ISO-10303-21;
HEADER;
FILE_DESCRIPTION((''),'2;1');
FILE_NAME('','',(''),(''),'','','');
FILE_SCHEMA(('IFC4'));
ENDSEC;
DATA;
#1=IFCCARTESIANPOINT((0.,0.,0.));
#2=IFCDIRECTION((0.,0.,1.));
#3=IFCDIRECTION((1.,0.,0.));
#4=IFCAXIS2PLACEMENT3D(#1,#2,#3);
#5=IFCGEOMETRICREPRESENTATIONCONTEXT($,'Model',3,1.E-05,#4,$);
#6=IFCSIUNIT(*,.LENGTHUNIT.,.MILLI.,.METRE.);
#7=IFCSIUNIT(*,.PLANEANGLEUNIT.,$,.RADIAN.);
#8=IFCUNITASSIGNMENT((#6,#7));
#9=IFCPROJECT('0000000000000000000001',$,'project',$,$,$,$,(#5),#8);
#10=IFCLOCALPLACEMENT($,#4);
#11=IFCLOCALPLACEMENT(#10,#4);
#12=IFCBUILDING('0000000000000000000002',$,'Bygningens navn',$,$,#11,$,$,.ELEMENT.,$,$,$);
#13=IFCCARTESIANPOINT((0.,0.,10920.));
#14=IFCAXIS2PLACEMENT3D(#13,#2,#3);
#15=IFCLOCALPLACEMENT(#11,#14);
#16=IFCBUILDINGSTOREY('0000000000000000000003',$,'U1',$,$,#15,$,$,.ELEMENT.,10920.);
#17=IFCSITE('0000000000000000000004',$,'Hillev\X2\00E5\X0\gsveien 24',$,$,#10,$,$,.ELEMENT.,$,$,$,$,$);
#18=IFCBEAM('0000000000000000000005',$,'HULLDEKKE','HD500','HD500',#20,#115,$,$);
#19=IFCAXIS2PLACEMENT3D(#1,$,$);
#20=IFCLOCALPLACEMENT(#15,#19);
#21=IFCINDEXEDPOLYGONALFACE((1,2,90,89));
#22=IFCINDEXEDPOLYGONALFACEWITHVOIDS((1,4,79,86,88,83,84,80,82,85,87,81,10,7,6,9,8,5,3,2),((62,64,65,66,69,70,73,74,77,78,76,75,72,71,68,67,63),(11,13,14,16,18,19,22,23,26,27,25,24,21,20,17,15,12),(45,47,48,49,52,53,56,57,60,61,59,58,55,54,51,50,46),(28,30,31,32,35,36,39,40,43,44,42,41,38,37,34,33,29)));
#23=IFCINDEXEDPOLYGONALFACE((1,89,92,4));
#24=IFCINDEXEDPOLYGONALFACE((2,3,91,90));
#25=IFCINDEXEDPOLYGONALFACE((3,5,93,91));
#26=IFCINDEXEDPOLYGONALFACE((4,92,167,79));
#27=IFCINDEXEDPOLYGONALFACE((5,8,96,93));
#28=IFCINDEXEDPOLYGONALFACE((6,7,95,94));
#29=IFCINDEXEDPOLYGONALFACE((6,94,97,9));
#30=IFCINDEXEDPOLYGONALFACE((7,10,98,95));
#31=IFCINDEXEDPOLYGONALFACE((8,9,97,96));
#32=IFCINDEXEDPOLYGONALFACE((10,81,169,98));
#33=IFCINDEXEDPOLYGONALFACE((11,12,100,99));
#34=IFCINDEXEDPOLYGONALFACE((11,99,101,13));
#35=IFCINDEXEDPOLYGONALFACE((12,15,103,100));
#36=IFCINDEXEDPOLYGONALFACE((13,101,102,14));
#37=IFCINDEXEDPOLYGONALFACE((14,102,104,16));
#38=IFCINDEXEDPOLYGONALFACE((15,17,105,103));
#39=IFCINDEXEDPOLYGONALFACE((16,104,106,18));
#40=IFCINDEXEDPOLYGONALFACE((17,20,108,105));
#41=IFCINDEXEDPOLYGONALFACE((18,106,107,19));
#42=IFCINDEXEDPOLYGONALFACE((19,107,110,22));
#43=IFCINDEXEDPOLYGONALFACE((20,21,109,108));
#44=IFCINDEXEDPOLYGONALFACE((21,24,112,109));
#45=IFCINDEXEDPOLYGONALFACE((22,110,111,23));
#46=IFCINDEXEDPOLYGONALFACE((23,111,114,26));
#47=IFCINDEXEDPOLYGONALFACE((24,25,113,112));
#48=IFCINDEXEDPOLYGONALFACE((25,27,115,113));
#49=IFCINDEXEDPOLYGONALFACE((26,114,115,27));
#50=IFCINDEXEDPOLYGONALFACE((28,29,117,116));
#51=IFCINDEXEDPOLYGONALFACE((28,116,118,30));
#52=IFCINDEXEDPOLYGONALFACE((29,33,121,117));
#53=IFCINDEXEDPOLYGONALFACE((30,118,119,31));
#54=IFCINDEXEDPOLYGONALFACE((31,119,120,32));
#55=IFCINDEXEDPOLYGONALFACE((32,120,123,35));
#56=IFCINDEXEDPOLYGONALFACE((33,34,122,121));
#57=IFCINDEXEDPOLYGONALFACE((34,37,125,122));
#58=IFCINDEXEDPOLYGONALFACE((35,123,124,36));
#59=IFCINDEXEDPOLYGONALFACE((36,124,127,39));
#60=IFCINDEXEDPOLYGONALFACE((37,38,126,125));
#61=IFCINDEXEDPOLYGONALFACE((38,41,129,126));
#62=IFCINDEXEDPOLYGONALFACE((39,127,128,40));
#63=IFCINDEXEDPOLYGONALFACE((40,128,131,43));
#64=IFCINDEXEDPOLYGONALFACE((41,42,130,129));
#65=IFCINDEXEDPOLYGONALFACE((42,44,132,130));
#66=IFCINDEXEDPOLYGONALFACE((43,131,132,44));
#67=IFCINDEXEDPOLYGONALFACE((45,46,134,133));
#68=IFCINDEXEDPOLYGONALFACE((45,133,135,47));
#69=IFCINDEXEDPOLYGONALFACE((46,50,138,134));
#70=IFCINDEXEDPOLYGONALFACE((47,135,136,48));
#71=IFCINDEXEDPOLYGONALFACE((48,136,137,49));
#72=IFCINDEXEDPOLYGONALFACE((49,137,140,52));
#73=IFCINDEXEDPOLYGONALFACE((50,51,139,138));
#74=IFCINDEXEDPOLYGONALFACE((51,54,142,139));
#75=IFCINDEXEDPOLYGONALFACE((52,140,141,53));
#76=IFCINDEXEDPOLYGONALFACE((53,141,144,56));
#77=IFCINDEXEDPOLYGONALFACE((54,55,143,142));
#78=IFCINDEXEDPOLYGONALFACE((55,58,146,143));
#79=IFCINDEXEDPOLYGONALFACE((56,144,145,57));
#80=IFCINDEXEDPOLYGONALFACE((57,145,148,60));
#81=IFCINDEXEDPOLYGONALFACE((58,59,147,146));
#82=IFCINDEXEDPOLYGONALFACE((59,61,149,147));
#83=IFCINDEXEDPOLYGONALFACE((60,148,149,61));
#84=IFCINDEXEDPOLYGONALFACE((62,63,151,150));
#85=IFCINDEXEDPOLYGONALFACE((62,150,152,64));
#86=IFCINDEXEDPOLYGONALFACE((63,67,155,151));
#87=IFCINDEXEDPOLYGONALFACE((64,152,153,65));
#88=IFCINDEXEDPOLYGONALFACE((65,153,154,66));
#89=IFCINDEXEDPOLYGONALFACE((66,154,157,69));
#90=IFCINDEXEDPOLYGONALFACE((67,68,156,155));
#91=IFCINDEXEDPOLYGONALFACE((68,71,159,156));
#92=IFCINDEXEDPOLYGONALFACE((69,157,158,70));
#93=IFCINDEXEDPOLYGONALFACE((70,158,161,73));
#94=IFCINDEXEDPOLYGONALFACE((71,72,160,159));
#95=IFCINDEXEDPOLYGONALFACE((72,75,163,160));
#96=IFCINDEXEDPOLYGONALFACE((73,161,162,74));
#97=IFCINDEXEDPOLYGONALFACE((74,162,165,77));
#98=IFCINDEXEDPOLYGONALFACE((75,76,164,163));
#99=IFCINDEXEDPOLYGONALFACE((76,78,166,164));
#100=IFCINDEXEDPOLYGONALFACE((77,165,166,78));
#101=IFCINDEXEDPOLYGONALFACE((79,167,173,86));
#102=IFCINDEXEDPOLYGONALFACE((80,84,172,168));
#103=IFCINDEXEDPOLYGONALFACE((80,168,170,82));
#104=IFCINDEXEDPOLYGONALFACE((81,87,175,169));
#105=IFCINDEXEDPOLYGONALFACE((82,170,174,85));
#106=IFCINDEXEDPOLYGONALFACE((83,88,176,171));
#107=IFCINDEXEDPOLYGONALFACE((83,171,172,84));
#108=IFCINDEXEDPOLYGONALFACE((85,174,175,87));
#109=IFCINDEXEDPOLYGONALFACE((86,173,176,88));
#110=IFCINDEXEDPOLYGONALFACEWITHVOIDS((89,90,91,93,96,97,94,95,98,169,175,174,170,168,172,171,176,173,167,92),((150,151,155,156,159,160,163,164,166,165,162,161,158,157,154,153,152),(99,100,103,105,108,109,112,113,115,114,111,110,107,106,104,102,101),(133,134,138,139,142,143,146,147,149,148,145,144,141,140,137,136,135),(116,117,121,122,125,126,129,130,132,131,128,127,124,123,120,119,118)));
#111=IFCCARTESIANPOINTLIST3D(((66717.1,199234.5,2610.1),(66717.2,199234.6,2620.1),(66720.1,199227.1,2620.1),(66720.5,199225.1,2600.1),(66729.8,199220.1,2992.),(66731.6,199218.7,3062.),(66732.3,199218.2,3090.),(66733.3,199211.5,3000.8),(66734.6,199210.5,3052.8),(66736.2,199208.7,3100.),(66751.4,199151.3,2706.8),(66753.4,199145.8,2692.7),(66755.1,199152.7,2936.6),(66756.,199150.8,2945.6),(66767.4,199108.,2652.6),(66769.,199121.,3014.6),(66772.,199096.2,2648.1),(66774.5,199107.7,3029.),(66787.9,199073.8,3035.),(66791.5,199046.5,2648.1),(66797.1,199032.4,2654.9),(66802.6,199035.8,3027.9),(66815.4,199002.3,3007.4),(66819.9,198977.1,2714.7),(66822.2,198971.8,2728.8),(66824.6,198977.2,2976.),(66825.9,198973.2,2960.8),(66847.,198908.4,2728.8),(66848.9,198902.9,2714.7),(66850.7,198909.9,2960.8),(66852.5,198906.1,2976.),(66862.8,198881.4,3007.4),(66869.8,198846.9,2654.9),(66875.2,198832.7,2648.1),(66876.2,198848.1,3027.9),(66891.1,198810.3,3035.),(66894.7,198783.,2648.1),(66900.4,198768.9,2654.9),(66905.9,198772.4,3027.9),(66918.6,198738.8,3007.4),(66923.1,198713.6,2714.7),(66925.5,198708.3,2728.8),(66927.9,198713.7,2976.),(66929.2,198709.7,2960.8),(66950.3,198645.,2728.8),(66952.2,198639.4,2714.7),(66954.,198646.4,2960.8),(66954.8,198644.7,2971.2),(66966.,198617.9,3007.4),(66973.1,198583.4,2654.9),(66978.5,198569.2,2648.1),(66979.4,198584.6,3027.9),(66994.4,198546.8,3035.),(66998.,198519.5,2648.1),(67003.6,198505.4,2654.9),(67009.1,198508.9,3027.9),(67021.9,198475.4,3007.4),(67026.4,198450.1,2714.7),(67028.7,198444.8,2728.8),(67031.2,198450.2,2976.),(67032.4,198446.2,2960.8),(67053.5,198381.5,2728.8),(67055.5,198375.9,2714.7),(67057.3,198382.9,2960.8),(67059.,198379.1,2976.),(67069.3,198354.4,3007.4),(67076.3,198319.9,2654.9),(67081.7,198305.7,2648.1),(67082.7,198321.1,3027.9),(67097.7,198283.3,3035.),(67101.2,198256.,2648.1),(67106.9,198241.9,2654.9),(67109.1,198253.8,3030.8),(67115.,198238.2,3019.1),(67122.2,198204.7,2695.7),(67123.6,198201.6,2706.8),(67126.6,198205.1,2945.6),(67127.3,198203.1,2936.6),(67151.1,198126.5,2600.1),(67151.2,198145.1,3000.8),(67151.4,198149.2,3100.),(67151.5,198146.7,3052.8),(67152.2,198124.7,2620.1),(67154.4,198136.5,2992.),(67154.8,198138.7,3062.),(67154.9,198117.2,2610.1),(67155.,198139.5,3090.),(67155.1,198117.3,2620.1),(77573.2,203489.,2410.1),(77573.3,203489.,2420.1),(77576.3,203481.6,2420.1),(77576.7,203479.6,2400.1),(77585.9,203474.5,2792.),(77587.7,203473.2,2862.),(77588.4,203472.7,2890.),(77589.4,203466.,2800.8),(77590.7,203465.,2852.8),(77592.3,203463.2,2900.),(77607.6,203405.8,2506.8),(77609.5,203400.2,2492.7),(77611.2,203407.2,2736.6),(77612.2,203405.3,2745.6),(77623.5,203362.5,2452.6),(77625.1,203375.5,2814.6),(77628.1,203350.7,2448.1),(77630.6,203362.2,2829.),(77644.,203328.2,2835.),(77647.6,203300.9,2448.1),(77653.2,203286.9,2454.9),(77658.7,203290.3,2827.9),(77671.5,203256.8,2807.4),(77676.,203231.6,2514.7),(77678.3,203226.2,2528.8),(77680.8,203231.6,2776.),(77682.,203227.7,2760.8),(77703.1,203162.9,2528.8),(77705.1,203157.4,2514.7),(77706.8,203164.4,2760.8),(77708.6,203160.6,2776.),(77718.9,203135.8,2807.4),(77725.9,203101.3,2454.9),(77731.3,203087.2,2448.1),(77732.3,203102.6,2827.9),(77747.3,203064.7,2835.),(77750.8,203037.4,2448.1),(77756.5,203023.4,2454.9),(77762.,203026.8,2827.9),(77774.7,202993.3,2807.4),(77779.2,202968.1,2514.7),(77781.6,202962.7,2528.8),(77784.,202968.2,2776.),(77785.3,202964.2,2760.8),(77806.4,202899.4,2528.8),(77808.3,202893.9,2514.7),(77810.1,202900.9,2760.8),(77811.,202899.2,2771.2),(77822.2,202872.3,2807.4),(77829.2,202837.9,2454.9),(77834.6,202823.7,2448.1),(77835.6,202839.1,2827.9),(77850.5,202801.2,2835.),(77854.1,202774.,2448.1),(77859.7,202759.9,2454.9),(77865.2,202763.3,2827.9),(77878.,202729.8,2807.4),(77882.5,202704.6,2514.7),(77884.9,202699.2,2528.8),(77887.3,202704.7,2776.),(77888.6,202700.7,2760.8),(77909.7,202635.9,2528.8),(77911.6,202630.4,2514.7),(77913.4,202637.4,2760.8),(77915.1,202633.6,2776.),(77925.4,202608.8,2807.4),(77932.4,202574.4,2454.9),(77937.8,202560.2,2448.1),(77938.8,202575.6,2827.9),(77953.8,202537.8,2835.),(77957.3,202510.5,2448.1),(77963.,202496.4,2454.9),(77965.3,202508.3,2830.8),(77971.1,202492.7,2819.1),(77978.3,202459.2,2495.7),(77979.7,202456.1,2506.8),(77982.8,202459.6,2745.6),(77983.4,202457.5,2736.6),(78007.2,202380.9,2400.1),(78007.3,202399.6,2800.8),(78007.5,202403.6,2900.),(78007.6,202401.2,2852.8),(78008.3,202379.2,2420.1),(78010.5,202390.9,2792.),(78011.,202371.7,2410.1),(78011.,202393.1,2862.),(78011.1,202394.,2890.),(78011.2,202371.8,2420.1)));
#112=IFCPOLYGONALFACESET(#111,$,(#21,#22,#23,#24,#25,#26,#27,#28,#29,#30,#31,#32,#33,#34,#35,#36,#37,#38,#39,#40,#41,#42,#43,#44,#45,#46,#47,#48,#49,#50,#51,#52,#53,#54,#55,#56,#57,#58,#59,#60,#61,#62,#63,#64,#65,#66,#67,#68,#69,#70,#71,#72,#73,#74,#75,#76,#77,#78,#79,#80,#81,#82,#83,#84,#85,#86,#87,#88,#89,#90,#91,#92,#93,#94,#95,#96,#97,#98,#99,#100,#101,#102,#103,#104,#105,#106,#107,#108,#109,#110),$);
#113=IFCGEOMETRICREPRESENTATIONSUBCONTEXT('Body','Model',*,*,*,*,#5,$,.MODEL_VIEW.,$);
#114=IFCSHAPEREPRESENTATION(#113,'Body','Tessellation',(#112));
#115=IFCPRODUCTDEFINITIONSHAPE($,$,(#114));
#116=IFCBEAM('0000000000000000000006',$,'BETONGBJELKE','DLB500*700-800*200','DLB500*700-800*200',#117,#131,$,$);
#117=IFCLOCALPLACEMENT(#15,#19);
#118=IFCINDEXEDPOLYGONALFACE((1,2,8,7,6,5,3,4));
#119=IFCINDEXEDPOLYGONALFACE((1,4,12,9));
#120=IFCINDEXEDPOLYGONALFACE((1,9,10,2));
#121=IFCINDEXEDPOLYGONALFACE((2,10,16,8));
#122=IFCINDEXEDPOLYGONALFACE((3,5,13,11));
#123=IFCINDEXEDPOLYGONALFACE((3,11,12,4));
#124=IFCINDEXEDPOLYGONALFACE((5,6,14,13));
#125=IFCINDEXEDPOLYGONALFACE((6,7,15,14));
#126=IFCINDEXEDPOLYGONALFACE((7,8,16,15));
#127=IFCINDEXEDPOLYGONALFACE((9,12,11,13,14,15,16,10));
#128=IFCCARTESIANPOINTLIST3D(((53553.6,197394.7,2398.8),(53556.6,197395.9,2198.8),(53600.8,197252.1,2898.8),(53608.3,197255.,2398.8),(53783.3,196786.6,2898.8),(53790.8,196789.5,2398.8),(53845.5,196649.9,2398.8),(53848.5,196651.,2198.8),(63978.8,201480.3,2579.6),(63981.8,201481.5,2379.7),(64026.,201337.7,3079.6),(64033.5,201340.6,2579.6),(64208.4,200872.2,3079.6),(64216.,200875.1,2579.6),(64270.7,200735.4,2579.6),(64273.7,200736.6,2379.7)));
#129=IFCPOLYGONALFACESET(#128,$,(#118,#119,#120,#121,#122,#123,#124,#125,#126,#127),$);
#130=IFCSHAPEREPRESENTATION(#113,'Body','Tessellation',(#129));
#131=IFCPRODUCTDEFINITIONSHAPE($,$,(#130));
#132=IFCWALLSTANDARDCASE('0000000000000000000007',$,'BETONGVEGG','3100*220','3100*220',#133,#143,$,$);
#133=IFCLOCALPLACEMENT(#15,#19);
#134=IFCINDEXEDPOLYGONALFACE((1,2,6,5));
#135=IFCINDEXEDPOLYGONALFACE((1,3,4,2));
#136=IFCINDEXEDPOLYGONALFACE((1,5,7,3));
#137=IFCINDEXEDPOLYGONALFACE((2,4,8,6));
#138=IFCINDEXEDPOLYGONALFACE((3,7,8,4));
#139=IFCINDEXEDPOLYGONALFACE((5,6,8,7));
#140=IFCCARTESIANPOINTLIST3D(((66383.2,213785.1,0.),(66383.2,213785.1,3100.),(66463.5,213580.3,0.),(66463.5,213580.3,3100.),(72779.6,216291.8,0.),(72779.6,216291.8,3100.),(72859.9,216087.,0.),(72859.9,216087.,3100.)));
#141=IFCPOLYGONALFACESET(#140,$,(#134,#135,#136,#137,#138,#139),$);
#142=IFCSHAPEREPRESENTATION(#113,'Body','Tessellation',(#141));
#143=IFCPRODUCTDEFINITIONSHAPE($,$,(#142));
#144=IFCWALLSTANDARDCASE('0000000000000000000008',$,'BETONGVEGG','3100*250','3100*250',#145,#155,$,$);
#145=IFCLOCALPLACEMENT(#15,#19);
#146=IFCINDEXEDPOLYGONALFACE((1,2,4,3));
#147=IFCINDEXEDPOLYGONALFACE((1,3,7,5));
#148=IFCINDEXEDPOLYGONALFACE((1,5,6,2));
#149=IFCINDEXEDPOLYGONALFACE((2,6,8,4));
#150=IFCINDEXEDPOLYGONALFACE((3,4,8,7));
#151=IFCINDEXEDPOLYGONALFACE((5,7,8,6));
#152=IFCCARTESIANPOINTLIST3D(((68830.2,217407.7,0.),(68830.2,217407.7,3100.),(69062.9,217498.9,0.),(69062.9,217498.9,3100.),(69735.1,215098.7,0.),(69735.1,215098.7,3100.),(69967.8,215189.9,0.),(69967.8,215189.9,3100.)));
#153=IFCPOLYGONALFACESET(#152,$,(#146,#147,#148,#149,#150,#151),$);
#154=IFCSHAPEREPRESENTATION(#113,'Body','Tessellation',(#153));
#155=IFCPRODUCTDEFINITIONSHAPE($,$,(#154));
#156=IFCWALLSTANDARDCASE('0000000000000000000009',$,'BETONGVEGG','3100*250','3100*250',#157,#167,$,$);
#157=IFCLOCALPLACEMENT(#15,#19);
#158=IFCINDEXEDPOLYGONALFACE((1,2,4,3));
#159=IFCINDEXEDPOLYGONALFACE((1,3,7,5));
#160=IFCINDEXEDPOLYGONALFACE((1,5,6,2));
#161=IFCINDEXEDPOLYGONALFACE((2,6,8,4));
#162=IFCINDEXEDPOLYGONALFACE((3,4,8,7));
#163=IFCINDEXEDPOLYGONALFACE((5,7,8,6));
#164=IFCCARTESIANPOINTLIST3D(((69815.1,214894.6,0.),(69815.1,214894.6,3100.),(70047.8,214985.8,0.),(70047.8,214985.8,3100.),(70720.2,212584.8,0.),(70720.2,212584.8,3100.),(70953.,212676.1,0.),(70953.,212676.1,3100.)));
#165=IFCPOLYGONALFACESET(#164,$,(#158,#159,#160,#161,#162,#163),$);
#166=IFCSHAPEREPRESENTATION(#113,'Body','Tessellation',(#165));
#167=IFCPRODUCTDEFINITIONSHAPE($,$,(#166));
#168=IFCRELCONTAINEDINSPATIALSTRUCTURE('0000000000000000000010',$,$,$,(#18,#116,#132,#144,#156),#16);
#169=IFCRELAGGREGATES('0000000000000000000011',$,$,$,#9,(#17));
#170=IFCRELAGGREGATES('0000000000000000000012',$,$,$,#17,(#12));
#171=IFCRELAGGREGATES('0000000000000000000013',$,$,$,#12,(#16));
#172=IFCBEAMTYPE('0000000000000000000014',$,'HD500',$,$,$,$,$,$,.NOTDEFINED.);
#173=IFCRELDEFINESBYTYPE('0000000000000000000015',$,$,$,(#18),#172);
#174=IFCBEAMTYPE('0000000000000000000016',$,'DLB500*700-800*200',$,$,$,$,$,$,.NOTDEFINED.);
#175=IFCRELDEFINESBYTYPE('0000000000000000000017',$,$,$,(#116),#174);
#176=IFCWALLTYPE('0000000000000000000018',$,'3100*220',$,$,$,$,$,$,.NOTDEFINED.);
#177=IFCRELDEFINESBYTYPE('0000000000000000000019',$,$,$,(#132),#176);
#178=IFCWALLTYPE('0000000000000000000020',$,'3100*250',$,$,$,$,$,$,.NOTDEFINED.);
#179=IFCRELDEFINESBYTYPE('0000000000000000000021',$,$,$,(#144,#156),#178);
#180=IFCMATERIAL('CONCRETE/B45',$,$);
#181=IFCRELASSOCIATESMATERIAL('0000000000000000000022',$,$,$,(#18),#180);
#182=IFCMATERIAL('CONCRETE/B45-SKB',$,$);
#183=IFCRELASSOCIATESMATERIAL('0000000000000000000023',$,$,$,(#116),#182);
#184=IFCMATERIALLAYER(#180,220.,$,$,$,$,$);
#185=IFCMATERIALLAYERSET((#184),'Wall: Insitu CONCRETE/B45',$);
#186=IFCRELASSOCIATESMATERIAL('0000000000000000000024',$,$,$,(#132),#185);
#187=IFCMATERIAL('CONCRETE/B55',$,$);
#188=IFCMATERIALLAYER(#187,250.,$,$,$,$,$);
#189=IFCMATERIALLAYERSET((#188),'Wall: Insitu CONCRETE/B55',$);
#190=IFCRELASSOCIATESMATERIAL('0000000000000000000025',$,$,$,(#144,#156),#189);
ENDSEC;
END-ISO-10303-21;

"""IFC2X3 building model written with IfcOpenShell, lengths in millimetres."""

from ifc_helpers import new_model, si_unit, frame, frame_2d, origin_with_axes, place, context, subcontext, project, spatial, polyline, rectangle, outline, extrude, material, layer, layer_set, layer_usage, type_object, element, save


model = new_model("IFC2X3")

# Units and contexts
model_context = context("Model", 3, precision=1e-05, world=origin_with_axes())
body_context = subcontext(model_context, "Body", "Model", "MODEL_VIEW")
ifc_project = project(units=[si_unit("LENGTHUNIT", "METRE", prefix="MILLI"), si_unit("PLANEANGLEUNIT", "RADIAN")], contexts=[model_context])

# Site, building, storey
site_placement = place(None, origin_with_axes())
site = spatial("IfcSite", under=ifc_project, at=site_placement, Name="Hillevågsveien 24", CompositionType="ELEMENT")
building_placement = place(site_placement, origin_with_axes())
building = spatial("IfcBuilding", under=site, at=building_placement, Name="Bygningens navn", CompositionType="ELEMENT")
storey_placement = place(building_placement, frame((0.0, 0.0, 10920.0), z_axis=(0.0, 0.0, 1.0), x_axis=(1.0, 0.0, 0.0)))
storey = spatial("IfcBuildingStorey", under=building, at=storey_placement, Name="U1", CompositionType="ELEMENT", Elevation=10920.0)

# Shared definitions
ifc_material_1 = material(Name="CONCRETE/B55")

# Beams
ifc_material_2 = material(Name="CONCRETE/B45")
beam_type_1 = type_object("IfcBeamType", Name="HD500", PredefinedType="NOTDEFINED")
beam_1_placement = place(storey_placement, frame((66939.8, 198677.4, 2850.0), z_axis=(0.015968, 0.006258, 0.999853), x_axis=(0.930919, 0.364823, -0.01715)))
element("IfcBeam", 1, at=beam_1_placement, inside=storey, type_object=beam_type_1, material=ifc_material_2, Name="HULLDEKKE", Description="HD500", ObjectType="HD500", context=body_context, shape_type="SweptSolid", body=[
    extrude(outline(polyline([(581.9, 142.0), (592.0, -230.0), (600.0, -230.0), (600.0, -240.0), (590.0, -250.0), (-590.0, -250.0), (-600.0, -240.0), (-600.0, -230.0), (-592.0, -230.0), (-581.9, 142.0), (-572.7, 150.7), (-571.3, 202.8), (-580.0, 212.0), (-579.3, 240.0), (-569.0, 250.0), (569.0, 250.0), (579.3, 240.0), (580.0, 212.0), (571.3, 202.8), (572.7, 150.7), (581.9, 142.0)]), holes=[polyline([(466.4, -195.1), (506.6, -154.3), (510.0, -143.2), (510.0, 86.5), (507.8, 95.6), (472.8, 169.1), (456.2, 180.7), (424.5, 185.0), (383.8, 177.9), (348.0, 157.4), (321.2, 126.0), (317.0, 110.8), (317.0, -121.2), (322.9, -135.4), (382.6, -195.1), (397.8, -202.0), (451.2, -202.0), (466.4, -195.1)]), polyline([(183.4, -195.1), (243.1, -135.4), (249.0, -121.2), (249.0, 110.8), (244.8, 126.0), (218.0, 157.4), (182.2, 177.9), (141.5, 185.0), (100.8, 177.9), (65.0, 157.4), (35.9, 121.2), (34.0, 110.8), (34.0, -121.2), (39.9, -135.4), (99.6, -195.1), (114.8, -202.0), (168.2, -202.0), (183.4, -195.1)]), polyline([(-99.6, -195.1), (-39.9, -135.4), (-34.0, -121.2), (-34.0, 110.8), (-38.2, 126.0), (-65.0, 157.4), (-100.8, 177.9), (-141.5, 185.0), (-182.2, 177.9), (-218.0, 157.4), (-244.8, 126.0), (-249.0, 110.8), (-249.0, -121.2), (-243.1, -135.4), (-183.4, -195.1), (-168.2, -202.0), (-114.8, -202.0), (-99.6, -195.1)]), polyline([(-382.6, -195.1), (-322.9, -135.4), (-317.0, -121.2), (-317.0, 110.8), (-321.2, 126.0), (-348.0, 157.4), (-383.8, 177.9), (-424.5, 185.0), (-461.0, 179.0), (-475.4, 164.6), (-507.9, 95.6), (-510.0, 86.5), (-510.0, -143.2), (-504.1, -157.4), (-463.9, -197.5), (-451.2, -202.0), (-397.8, -202.0), (-382.6, -195.1)])]), frame((11661.7, 0.0, 0.0), z_axis=(-1.0, 0.0, 0.0), x_axis=(0.0, -1.0, 0.0)), (0.0, 0.0, 1.0), 11661.7),
])
ifc_material_3 = material(Name="CONCRETE/B45-SKB")
beam_type_2 = type_object("IfcBeamType", Name="DLB500*700-800*200", PredefinedType="NOTDEFINED")
beam_2_placement = place(storey_placement, frame((64122.5, 201107.0, 2729.6), z_axis=(-0.015033, -0.005891, 0.99987), x_axis=(-0.930934, -0.364829, -0.016146)))
element("IfcBeam", 2, at=beam_2_placement, inside=storey, type_object=beam_type_2, material=ifc_material_3, Name="BETONGBJELKE", Description="DLB500*700-800*200", ObjectType="DLB500*700-800*200", context=body_context, shape_type="SweptSolid", body=[
    extrude(outline(polyline([(400.0, -150.0), (400.0, -350.0), (-400.0, -350.0), (-400.0, -150.0), (-250.0, -150.0), (-250.0, 350.0), (250.0, 350.0), (250.0, -150.0), (400.0, -150.0)])), frame((11198.6, 0.0, 0.0), z_axis=(-1.0, 0.0, 0.0), x_axis=(0.0, -1.0, 0.0)), (0.0, 0.0, 1.0), 11198.6),
])

# Walls
ifc_layer_1 = layer(ifc_material_2, 220.0)
ifc_layer_set_1 = layer_set([ifc_layer_1], Name="Wall: Insitu CONCRETE/B45")
ifc_layer_usage_1 = layer_usage(ifc_layer_set_1, "AXIS2", "POSITIVE", -110.0)
wall_type_1 = type_object("IfcWallType", Name="3100*220", PredefinedType="NOTDEFINED")
wall_1_placement = place(storey_placement, frame((66423.4, 213682.7, 0.0), z_axis=(0.0, 0.0, 1.0), x_axis=(0.931056, 0.364877, 0.0)))
element("IfcWallStandardCase", 3, at=wall_1_placement, inside=storey, type_object=wall_type_1, material=ifc_layer_usage_1, Name="BETONGVEGG", Description="3100*220", ObjectType="3100*220", context=body_context, shape_type="SweptSolid", body=[
    extrude(rectangle(XDim=6870.0, YDim=220.0, at=frame_2d((0.0, 3435.0), x_axis=(0.0, -1.0))), frame((0.0, 0.0, 0.0), z_axis=(0.0, 0.0, 1.0), x_axis=(0.0, -1.0, 0.0)), (0.0, 0.0, 1.0), 3100.0),
])
ifc_layer_2 = layer(ifc_material_1, 250.0)
ifc_layer_set_2 = layer_set([ifc_layer_2], Name="Wall: Insitu CONCRETE/B55")
ifc_layer_usage_2 = layer_usage(ifc_layer_set_2, "AXIS2", "POSITIVE", -125.0)
wall_type_2 = type_object("IfcWallType", Name="3100*250", PredefinedType="NOTDEFINED")
wall_2_placement = place(storey_placement, frame((68946.5, 217453.3, 0.0), z_axis=(0.0, 0.0, 1.0), x_axis=(0.364877, -0.931056, 0.0)))
element("IfcWallStandardCase", 4, at=wall_2_placement, inside=storey, type_object=wall_type_2, material=ifc_layer_usage_2, Name="BETONGVEGG", Description="3100*250", ObjectType="3100*250", context=body_context, shape_type="SweptSolid", body=[
    extrude(rectangle(XDim=2480.0, YDim=250.0, at=frame_2d((0.0, 1240.0), x_axis=(0.0, -1.0))), frame((0.0, 0.0, 0.0), z_axis=(0.0, 0.0, 1.0), x_axis=(0.0, -1.0, 0.0)), (0.0, 0.0, 1.0), 3100.0),
])
ifc_layer_usage_3 = layer_usage(ifc_layer_set_2, "AXIS2", "POSITIVE", -125.0)
wall_3_placement = place(storey_placement, frame((69931.4, 214940.2, 0.0), z_axis=(0.0, 0.0, 1.0), x_axis=(0.364877, -0.931056, 0.0)))
element("IfcWallStandardCase", 5, at=wall_3_placement, inside=storey, type_object=wall_type_2, material=ifc_layer_usage_3, Name="BETONGVEGG", Description="3100*250", ObjectType="3100*250", context=body_context, shape_type="SweptSolid", body=[
    extrude(rectangle(XDim=2480.7, YDim=250.0, at=frame_2d((0.0, 1240.4), x_axis=(0.0, -1.0))), frame((0.0, 0.0, 0.0), z_axis=(0.0, 0.0, 1.0), x_axis=(0.0, -1.0, 0.0)), (0.0, 0.0, 1.0), 3100.0),
])

save(model, "model.ifc")
